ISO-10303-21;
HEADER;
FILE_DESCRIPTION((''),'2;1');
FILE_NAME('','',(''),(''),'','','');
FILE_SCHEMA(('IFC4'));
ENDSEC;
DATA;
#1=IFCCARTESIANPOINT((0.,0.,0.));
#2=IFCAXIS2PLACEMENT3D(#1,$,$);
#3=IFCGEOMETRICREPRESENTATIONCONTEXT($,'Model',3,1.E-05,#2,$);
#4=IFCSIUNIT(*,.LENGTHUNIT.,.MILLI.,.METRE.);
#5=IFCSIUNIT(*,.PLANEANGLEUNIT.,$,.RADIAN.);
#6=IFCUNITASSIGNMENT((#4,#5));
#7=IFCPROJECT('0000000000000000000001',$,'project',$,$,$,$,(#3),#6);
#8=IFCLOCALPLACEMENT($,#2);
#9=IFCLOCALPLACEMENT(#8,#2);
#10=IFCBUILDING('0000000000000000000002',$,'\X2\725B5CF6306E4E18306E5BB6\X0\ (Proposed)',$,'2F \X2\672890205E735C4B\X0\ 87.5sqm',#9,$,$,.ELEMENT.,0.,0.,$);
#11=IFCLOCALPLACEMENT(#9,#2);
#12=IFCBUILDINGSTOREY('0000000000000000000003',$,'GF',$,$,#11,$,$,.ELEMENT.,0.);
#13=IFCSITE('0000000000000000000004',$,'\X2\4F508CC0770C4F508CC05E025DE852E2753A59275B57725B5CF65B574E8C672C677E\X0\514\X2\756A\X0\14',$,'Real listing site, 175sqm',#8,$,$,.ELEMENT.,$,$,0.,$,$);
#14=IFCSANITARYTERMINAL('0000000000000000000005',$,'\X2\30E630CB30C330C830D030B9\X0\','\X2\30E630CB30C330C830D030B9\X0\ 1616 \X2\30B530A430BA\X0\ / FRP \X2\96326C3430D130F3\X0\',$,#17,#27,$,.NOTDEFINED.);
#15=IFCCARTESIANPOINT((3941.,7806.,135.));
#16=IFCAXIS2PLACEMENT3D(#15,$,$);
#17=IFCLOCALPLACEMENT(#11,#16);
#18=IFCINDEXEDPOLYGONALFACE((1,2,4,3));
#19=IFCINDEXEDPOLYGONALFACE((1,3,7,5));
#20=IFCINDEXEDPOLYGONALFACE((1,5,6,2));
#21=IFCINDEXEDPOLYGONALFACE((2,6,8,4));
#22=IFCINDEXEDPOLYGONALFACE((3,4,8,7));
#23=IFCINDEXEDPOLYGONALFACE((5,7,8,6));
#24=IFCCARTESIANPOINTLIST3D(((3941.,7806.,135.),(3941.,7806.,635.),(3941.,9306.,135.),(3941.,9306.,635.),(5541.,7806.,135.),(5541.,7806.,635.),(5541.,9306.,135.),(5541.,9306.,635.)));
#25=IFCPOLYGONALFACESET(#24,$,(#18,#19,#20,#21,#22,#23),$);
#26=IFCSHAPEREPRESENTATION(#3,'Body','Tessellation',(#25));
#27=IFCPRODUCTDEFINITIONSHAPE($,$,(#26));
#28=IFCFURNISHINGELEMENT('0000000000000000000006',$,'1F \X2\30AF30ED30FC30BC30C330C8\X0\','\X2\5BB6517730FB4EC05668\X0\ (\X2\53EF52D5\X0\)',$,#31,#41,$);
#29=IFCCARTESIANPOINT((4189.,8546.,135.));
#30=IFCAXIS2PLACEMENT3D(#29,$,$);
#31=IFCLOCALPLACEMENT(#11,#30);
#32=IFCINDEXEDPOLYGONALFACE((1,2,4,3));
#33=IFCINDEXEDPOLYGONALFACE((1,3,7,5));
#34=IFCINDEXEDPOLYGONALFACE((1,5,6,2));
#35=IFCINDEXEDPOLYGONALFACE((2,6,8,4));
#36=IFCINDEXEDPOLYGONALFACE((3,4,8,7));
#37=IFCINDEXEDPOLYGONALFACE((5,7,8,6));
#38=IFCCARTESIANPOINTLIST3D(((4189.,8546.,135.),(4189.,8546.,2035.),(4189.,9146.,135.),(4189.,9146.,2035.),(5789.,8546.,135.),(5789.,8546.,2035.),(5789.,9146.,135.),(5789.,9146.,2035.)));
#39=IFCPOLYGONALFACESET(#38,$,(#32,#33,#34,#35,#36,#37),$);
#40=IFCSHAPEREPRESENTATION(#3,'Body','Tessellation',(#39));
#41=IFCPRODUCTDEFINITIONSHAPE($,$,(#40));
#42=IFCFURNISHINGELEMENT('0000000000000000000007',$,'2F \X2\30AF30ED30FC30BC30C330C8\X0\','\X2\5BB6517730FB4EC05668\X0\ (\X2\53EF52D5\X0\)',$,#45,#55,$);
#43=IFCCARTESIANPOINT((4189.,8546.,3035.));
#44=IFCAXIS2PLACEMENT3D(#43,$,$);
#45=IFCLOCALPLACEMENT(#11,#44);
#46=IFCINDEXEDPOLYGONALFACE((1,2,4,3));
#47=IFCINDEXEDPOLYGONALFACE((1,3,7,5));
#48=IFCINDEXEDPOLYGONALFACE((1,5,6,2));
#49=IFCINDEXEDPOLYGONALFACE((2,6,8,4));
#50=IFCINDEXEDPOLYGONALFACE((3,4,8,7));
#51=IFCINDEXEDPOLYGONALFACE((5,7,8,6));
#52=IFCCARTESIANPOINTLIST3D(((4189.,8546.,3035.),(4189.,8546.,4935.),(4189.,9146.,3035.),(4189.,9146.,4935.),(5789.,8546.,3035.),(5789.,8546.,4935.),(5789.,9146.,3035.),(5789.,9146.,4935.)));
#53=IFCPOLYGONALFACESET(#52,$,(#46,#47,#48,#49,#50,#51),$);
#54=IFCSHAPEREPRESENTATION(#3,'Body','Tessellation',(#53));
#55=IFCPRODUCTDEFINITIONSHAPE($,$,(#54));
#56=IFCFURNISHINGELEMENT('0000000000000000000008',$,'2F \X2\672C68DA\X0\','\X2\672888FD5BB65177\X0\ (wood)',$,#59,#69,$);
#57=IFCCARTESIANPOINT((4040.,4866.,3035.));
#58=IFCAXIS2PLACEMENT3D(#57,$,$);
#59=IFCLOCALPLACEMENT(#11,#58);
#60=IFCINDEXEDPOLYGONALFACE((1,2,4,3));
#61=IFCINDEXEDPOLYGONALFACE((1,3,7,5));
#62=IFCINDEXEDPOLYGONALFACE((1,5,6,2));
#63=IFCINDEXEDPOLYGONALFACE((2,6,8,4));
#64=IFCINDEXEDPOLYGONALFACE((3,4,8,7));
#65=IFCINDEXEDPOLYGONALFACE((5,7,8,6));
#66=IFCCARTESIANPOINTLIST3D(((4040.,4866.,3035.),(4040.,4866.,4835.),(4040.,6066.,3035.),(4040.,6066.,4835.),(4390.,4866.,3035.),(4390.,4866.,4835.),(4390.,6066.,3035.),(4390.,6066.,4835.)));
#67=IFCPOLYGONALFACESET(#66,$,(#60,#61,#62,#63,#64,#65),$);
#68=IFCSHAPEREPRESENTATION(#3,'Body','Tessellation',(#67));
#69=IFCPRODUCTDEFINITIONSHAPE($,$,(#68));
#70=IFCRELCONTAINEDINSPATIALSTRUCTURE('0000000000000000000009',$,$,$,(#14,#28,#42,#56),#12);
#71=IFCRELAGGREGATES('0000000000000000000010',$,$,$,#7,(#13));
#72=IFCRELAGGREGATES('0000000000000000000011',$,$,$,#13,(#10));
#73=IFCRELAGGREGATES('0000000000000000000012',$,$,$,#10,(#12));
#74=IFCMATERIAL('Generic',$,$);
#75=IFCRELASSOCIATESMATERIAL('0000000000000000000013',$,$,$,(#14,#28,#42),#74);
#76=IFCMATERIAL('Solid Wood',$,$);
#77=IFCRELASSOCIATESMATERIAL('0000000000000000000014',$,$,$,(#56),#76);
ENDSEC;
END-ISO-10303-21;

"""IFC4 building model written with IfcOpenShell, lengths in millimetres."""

from ifc_helpers import new_model, si_unit, frame, frame_2d, origin, place, context, project, spatial, rectangle, extrude, material, element, save


model = new_model("IFC4")

# Units and contexts
model_context = context("Model", 3, precision=1e-05, world=origin())
ifc_project = project(units=[si_unit("LENGTHUNIT", "METRE", prefix="MILLI"), si_unit("PLANEANGLEUNIT", "RADIAN")], contexts=[model_context])

# Site, building, storey
site_placement = place(None, origin())
site = spatial("IfcSite", under=ifc_project, at=site_placement, Name="佐賀県佐賀市巨勢町大字牛島字二本松514番14", ObjectType="Real listing site, 175sqm", CompositionType="ELEMENT", RefElevation=0.0)
building_placement = place(site_placement, origin())
building = spatial("IfcBuilding", under=site, at=building_placement, Name="牛島の丘の家 (Proposed)", ObjectType="2F 木造平屋 87.5sqm", CompositionType="ELEMENT", ElevationOfRefHeight=0.0, ElevationOfTerrain=0.0)
storey_placement = place(building_placement, origin())
storey = spatial("IfcBuildingStorey", under=building, at=storey_placement, Name="GF", CompositionType="ELEMENT", Elevation=0.0)

# Shared definitions
ifc_material_1 = material(Name="Solid Wood")

# Shared definitions
ifc_material_2 = material(Name="Generic")

# Sanitary terminal
sanitary_terminal_placement = place(storey_placement, frame((3941.0, 7806.0, 135.0)))
element("IfcSanitaryTerminal", 1, at=sanitary_terminal_placement, inside=storey, material=ifc_material_2, Name="ユニットバス", Description="ユニットバス 1616 サイズ / FRP 防水パン", PredefinedType="NOTDEFINED", context=model_context, shape_type="SweptSolid", body=[
    extrude(rectangle(XDim=1600.0, YDim=1500.0, at=frame_2d((800.0, 750.0))), frame((3941.0, 7806.0, 135.0)), (0.0, 0.0, 1.0), 500.0),
])

# Furnishing elements
furnishing_1_placement = place(storey_placement, frame((4189.0, 8546.0, 135.0)))
element("IfcFurnishingElement", 2, at=furnishing_1_placement, inside=storey, material=ifc_material_2, Name="1F クローゼット", Description="家具・什器 (可動)", context=model_context, shape_type="SweptSolid", body=[
    extrude(rectangle(XDim=1600.0, YDim=600.0, at=frame_2d((800.0, 300.0))), frame((4189.0, 8546.0, 135.0)), (0.0, 0.0, 1.0), 1900.0),
])
furnishing_2_placement = place(storey_placement, frame((4189.0, 8546.0, 3035.0)))
element("IfcFurnishingElement", 3, at=furnishing_2_placement, inside=storey, material=ifc_material_2, Name="2F クローゼット", Description="家具・什器 (可動)", context=model_context, shape_type="SweptSolid", body=[
    extrude(rectangle(XDim=1600.0, YDim=600.0, at=frame_2d((800.0, 300.0))), frame((4189.0, 8546.0, 3035.0)), (0.0, 0.0, 1.0), 1900.0),
])
furnishing_3_placement = place(storey_placement, frame((4040.0, 4866.0, 3035.0)))
element("IfcFurnishingElement", 4, at=furnishing_3_placement, inside=storey, material=ifc_material_1, Name="2F 本棚", Description="木製家具 (wood)", context=model_context, shape_type="SweptSolid", body=[
    extrude(rectangle(XDim=350.0, YDim=1200.0, at=frame_2d((175.0, 600.0))), frame((4040.0, 4866.0, 3035.0)), (0.0, 0.0, 1.0), 1800.0),
])

save(model, "model.ifc")
